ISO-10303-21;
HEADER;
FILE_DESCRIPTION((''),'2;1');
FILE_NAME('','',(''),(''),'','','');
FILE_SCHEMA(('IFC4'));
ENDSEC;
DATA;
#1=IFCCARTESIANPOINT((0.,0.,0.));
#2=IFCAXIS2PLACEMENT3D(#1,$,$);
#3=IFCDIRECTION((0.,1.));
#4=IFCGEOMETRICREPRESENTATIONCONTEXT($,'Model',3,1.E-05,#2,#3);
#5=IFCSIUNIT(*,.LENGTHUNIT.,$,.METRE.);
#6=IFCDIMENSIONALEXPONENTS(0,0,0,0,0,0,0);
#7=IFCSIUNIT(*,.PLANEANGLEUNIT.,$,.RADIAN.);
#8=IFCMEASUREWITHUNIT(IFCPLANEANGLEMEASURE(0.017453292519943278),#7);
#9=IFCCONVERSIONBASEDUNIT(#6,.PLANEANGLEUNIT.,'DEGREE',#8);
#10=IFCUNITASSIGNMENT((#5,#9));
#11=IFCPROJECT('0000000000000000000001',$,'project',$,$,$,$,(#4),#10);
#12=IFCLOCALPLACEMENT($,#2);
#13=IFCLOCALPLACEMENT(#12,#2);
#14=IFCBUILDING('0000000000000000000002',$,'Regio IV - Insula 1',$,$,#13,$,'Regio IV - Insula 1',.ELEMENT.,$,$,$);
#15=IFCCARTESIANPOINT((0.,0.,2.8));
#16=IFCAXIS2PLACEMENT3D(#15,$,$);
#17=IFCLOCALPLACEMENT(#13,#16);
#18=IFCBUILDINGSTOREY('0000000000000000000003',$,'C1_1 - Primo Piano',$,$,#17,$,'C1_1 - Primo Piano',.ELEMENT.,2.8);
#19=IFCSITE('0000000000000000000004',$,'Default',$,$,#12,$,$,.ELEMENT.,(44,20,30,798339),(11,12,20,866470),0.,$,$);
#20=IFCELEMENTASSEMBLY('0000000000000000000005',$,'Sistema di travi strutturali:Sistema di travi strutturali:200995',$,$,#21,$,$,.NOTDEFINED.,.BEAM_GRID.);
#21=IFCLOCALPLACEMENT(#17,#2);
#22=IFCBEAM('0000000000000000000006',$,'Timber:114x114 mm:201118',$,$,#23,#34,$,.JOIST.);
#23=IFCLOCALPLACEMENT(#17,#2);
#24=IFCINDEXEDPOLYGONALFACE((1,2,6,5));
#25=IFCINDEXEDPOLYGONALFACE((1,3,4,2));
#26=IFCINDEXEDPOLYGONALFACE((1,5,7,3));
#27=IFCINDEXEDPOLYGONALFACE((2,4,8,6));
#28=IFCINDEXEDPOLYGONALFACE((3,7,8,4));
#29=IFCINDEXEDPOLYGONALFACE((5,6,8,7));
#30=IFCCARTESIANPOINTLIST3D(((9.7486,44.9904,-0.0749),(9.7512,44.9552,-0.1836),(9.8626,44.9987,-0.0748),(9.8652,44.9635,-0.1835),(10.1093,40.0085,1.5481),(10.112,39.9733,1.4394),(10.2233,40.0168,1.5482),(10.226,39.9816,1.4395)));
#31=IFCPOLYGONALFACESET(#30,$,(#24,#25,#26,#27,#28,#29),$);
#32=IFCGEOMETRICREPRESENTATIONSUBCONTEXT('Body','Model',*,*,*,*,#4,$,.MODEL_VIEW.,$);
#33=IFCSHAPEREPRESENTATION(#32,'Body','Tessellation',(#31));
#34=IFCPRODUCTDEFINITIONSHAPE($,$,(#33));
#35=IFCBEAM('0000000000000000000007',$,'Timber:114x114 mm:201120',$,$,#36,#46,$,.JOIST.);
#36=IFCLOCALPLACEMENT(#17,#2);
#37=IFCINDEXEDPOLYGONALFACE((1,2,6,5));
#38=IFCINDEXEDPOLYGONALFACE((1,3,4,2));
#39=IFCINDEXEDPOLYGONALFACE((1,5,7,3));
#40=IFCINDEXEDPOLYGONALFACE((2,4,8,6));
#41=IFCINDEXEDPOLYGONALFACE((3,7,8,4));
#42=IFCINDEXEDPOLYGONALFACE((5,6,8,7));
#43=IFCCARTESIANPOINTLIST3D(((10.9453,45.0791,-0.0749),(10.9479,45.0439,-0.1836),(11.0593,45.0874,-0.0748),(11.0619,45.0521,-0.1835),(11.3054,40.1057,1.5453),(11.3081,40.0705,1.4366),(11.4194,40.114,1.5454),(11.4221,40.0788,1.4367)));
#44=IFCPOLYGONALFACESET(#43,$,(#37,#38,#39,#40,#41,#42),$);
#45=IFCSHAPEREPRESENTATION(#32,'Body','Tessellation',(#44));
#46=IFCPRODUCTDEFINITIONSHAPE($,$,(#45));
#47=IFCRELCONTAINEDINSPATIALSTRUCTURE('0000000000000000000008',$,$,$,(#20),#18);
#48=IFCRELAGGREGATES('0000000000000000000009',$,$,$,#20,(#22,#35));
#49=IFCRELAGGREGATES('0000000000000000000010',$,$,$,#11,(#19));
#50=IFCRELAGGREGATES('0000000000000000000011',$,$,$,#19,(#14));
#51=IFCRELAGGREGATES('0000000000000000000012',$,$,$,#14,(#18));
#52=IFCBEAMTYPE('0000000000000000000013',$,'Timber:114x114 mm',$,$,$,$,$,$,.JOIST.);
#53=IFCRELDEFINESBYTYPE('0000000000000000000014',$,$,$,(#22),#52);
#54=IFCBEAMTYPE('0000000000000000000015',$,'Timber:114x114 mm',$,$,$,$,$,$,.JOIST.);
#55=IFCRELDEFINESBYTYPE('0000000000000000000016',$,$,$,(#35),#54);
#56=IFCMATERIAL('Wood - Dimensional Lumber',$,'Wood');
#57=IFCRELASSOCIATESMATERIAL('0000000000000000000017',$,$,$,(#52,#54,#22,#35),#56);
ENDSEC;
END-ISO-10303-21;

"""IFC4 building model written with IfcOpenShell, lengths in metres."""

from ifc_helpers import new_model, entity, si_unit, converted_unit, direction, frame, origin, origin_2d_with_axis, place, context, subcontext, project, spatial, rectangle, extrude, source, transform, mapped, material, material_profile, profile_set, profile_usage, type_object, type_shapes, element, aggregate, save


model = new_model("IFC4")

# Units and contexts
model_context = context("Model", 3, precision=1e-05, world=origin(), true_north=direction((0.0, 1.0)))
body_context = subcontext(model_context, "Body", "Model", "MODEL_VIEW")
ifc_project = project(units=[si_unit("LENGTHUNIT", "METRE"), converted_unit("PLANEANGLEUNIT", "DEGREE", entity("IfcPlaneAngleMeasure", 0.017453292519943278), si_unit("PLANEANGLEUNIT", "RADIAN"), dimensions=[0, 0, 0, 0, 0, 0, 0])], contexts=[model_context])

# Site, building, storey
site_placement = place(None, origin())
site = spatial("IfcSite", under=ifc_project, at=site_placement, Name="Default", CompositionType="ELEMENT", RefLatitude=(44, 20, 30, 798339), RefLongitude=(11, 12, 20, 866470), RefElevation=0.0)
building_placement = place(site_placement, origin())
building = spatial("IfcBuilding", under=site, at=building_placement, Name="Regio IV - Insula 1", LongName="Regio IV - Insula 1", CompositionType="ELEMENT")
storey_placement = place(building_placement, frame((0.0, 0.0, 2.8)))
storey = spatial("IfcBuildingStorey", under=building, at=storey_placement, Name="C1_1 - Primo Piano", LongName="C1_1 - Primo Piano", CompositionType="ELEMENT", Elevation=2.8)

# Shared definitions
ifc_material = material(Name="Wood - Dimensional Lumber", Category="Wood")
ifc_material_profile = material_profile(ifc_material, rectangle(XDim=5.294, YDim=0.1143, at=origin_2d_with_axis()), Name="114x114 mm")
ifc_profile_set = profile_set([ifc_material_profile], Name="114x114 mm")
ifc_profile_usage = profile_usage(ifc_profile_set, cardinal=8)

# Element assembly
assembly_1_placement = place(storey_placement, origin())
assembly_1 = element("IfcElementAssembly", 1, at=assembly_1_placement, inside=storey, Name="Sistema di travi strutturali:Sistema di travi strutturali:200995", AssemblyPlace="NOTDEFINED", PredefinedType="BEAM_GRID")

# Beams
beam_type_1 = type_object("IfcBeamType", Name="Timber:114x114 mm", PredefinedType="JOIST", material=ifc_profile_set)
shared_shape_1 = source(origin(), body_context, "Body", "SweptSolid", [
    extrude(rectangle(XDim=5.252, YDim=0.1143, at=origin_2d_with_axis()), frame((0.0, 0.0, -0.0572), z_axis=(0.0, 0.0, 1.0), x_axis=(-1.0, 0.0, 0.0)), (0.0, 0.0, 1.0), 0.1143),
])
type_shapes(beam_type_1, [shared_shape_1])
beam_1_placement = place(assembly_1_placement, frame((9.9873, 42.486, 0.6823), z_axis=(-0.022823, 0.308173, 0.951057), x_axis=(0.068685, -0.948573, 0.309017)))
beam_1 = element("IfcBeam", 2, at=beam_1_placement, type_object=beam_type_1, material=ifc_profile_usage, Name="Timber:114x114 mm:201118", PredefinedType="JOIST", context=body_context, shape_type="MappedRepresentation", body=[
    mapped(shared_shape_1, transform((0.0, 0.0, 0.0), scale=1.0)),
])
beam_type_2 = type_object("IfcBeamType", Name="Timber:114x114 mm", PredefinedType="JOIST", material=ifc_profile_set)
shared_shape_2 = source(origin(), body_context, "Body", "SweptSolid", [
    extrude(rectangle(XDim=5.243, YDim=0.1143, at=origin_2d_with_axis()), frame((0.0, 0.0, -0.0572), z_axis=(0.0, 0.0, 1.0), x_axis=(-1.0, 0.0, 0.0)), (0.0, 0.0, 1.0), 0.1143),
])
type_shapes(beam_type_2, [shared_shape_2])
beam_2_placement = place(assembly_1_placement, frame((11.1837, 42.5789, 0.6809), z_axis=(-0.022823, 0.308173, 0.951057), x_axis=(0.068685, -0.948573, 0.309017)))
beam_2 = element("IfcBeam", 3, at=beam_2_placement, type_object=beam_type_2, material=ifc_profile_usage, Name="Timber:114x114 mm:201120", PredefinedType="JOIST", context=body_context, shape_type="MappedRepresentation", body=[
    mapped(shared_shape_2, transform((0.0, 0.0, 0.0), scale=1.0)),
])
aggregate(assembly_1, [beam_1, beam_2])

save(model, "model.ifc")
